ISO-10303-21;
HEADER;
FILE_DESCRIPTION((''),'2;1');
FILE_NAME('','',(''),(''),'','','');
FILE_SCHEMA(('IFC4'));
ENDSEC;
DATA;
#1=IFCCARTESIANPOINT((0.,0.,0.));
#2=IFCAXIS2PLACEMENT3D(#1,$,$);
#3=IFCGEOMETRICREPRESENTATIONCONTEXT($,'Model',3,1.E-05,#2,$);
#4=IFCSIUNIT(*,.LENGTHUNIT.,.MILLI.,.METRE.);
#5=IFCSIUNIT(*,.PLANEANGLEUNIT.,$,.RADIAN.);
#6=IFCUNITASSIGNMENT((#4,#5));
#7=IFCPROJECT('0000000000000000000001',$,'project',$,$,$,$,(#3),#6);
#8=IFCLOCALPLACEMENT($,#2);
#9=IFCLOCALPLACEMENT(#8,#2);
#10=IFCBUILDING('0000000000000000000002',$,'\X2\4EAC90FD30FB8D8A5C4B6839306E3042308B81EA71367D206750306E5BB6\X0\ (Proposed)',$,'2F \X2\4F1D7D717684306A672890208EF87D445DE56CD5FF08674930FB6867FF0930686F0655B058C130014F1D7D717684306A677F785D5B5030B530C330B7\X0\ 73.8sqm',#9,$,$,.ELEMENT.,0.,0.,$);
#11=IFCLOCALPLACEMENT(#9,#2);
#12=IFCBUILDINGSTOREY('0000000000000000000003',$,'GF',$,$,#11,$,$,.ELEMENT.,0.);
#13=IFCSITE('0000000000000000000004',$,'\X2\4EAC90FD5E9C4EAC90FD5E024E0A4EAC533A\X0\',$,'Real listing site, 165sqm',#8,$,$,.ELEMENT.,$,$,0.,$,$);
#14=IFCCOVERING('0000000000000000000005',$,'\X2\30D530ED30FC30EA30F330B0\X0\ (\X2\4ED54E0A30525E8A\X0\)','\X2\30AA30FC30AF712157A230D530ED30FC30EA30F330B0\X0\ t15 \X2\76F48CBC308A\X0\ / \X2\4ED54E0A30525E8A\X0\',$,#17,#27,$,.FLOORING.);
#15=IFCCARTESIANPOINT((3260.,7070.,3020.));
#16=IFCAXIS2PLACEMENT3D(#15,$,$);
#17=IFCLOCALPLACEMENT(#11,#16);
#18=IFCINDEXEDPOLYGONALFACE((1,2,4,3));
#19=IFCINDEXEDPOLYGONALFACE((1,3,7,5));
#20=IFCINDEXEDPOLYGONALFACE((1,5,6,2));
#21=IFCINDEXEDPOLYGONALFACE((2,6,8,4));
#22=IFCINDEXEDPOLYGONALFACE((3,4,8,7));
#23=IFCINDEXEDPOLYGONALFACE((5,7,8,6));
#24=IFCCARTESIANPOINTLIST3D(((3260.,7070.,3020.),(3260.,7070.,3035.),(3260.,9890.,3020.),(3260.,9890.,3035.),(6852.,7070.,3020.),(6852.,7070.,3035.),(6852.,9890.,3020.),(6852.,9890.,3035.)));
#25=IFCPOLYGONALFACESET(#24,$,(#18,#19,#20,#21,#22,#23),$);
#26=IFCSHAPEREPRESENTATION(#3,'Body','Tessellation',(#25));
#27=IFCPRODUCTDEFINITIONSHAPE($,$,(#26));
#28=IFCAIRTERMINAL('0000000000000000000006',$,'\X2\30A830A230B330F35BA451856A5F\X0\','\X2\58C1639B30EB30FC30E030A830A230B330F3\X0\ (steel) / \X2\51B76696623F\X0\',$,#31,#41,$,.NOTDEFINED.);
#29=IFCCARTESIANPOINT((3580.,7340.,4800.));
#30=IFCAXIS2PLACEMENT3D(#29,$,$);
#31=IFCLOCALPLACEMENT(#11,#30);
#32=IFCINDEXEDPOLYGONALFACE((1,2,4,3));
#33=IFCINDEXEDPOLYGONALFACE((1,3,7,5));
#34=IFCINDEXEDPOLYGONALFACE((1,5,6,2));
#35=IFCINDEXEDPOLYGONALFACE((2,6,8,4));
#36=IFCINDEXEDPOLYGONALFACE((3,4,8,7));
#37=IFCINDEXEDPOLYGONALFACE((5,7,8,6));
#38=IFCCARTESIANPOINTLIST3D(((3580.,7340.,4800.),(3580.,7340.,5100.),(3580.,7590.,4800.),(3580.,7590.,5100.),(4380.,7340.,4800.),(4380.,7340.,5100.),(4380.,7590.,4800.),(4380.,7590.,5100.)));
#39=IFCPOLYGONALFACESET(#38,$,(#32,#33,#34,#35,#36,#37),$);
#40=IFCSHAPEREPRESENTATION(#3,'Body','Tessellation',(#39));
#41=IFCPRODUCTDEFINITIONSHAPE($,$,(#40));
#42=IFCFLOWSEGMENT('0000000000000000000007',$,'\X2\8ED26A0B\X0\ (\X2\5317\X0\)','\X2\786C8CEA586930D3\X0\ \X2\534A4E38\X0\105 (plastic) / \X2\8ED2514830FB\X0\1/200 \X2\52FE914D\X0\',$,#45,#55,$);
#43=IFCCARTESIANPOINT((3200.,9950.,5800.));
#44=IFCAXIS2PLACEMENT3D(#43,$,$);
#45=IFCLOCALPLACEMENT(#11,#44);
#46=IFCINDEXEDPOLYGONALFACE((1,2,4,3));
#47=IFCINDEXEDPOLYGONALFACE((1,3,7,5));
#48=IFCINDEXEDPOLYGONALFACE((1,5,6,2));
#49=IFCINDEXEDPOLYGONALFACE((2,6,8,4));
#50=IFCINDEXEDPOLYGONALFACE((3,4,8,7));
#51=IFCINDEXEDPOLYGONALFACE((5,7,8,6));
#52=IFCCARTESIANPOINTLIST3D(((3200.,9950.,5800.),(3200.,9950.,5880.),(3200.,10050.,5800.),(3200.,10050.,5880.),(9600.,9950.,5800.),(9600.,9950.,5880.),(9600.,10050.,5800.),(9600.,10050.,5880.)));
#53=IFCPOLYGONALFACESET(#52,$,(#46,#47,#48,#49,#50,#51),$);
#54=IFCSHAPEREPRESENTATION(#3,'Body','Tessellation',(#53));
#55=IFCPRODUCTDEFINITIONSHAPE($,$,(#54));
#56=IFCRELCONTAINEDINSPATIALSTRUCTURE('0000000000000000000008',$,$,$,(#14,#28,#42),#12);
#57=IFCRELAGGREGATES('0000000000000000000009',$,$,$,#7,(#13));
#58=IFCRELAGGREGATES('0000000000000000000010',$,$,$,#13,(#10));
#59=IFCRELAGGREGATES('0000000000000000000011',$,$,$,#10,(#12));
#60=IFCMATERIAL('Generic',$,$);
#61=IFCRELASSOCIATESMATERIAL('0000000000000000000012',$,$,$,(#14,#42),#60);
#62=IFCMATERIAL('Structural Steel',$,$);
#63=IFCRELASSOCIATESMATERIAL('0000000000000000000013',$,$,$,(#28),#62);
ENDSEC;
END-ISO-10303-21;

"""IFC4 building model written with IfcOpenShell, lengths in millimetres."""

from ifc_helpers import new_model, si_unit, frame, frame_2d, origin, place, context, project, spatial, rectangle, extrude, material, element, save


model = new_model("IFC4")

# Units and contexts
model_context = context("Model", 3, precision=1e-05, world=origin())
ifc_project = project(units=[si_unit("LENGTHUNIT", "METRE", prefix="MILLI"), si_unit("PLANEANGLEUNIT", "RADIAN")], contexts=[model_context])

# Site, building, storey
site_placement = place(None, origin())
site = spatial("IfcSite", under=ifc_project, at=site_placement, Name="京都府京都市上京区", ObjectType="Real listing site, 165sqm", CompositionType="ELEMENT", RefElevation=0.0)
building_placement = place(site_placement, origin())
building = spatial("IfcBuilding", under=site, at=building_placement, Name="京都・越屋根のある自然素材の家 (Proposed)", ObjectType="2F 伝統的な木造軸組工法（杉・桧）と漆喰壁、伝統的な板硝子サッシ 73.8sqm", CompositionType="ELEMENT", ElevationOfRefHeight=0.0, ElevationOfTerrain=0.0)
storey_placement = place(building_placement, origin())
storey = spatial("IfcBuildingStorey", under=building, at=storey_placement, Name="GF", CompositionType="ELEMENT", Elevation=0.0)

# Shared definitions
ifc_material_1 = material(Name="Structural Steel")

# Covering
ifc_material_2 = material(Name="Generic")
covering_placement = place(storey_placement, frame((3260.0, 7070.0, 3020.0)))
element("IfcCovering", 1, at=covering_placement, inside=storey, material=ifc_material_2, Name="フローリング (仕上げ床)", Description="オーク無垢フローリング t15 直貼り / 仕上げ床", PredefinedType="FLOORING", context=model_context, shape_type="SweptSolid", body=[
    extrude(rectangle(XDim=3592.0, YDim=2820.0, at=frame_2d((1796.0, 1410.0))), frame((3260.0, 7070.0, 3020.0)), (0.0, 0.0, 1.0), 15.0),
])

# Air terminal
air_terminal_placement = place(storey_placement, frame((3580.0, 7340.0, 4800.0)))
element("IfcAirTerminal", 2, at=air_terminal_placement, inside=storey, material=ifc_material_1, Name="エアコン室内機", Description="壁掛ルームエアコン (steel) / 冷暖房", PredefinedType="NOTDEFINED", context=model_context, shape_type="SweptSolid", body=[
    extrude(rectangle(XDim=800.0, YDim=250.0, at=frame_2d((400.0, 125.0))), frame((3580.0, 7340.0, 4800.0)), (0.0, 0.0, 1.0), 300.0),
])

# Flow segment
flow_segment_placement = place(storey_placement, frame((3200.0, 9950.0, 5800.0)))
element("IfcFlowSegment", 3, at=flow_segment_placement, inside=storey, material=ifc_material_2, Name="軒樋 (北)", Description="硬質塩ビ 半丸105 (plastic) / 軒先・1/200 勾配", context=model_context, shape_type="SweptSolid", body=[
    extrude(rectangle(XDim=6400.0, YDim=100.0, at=frame_2d((3200.0, 50.0))), frame((3200.0, 9950.0, 5800.0)), (0.0, 0.0, 1.0), 80.0),
])

save(model, "model.ifc")
